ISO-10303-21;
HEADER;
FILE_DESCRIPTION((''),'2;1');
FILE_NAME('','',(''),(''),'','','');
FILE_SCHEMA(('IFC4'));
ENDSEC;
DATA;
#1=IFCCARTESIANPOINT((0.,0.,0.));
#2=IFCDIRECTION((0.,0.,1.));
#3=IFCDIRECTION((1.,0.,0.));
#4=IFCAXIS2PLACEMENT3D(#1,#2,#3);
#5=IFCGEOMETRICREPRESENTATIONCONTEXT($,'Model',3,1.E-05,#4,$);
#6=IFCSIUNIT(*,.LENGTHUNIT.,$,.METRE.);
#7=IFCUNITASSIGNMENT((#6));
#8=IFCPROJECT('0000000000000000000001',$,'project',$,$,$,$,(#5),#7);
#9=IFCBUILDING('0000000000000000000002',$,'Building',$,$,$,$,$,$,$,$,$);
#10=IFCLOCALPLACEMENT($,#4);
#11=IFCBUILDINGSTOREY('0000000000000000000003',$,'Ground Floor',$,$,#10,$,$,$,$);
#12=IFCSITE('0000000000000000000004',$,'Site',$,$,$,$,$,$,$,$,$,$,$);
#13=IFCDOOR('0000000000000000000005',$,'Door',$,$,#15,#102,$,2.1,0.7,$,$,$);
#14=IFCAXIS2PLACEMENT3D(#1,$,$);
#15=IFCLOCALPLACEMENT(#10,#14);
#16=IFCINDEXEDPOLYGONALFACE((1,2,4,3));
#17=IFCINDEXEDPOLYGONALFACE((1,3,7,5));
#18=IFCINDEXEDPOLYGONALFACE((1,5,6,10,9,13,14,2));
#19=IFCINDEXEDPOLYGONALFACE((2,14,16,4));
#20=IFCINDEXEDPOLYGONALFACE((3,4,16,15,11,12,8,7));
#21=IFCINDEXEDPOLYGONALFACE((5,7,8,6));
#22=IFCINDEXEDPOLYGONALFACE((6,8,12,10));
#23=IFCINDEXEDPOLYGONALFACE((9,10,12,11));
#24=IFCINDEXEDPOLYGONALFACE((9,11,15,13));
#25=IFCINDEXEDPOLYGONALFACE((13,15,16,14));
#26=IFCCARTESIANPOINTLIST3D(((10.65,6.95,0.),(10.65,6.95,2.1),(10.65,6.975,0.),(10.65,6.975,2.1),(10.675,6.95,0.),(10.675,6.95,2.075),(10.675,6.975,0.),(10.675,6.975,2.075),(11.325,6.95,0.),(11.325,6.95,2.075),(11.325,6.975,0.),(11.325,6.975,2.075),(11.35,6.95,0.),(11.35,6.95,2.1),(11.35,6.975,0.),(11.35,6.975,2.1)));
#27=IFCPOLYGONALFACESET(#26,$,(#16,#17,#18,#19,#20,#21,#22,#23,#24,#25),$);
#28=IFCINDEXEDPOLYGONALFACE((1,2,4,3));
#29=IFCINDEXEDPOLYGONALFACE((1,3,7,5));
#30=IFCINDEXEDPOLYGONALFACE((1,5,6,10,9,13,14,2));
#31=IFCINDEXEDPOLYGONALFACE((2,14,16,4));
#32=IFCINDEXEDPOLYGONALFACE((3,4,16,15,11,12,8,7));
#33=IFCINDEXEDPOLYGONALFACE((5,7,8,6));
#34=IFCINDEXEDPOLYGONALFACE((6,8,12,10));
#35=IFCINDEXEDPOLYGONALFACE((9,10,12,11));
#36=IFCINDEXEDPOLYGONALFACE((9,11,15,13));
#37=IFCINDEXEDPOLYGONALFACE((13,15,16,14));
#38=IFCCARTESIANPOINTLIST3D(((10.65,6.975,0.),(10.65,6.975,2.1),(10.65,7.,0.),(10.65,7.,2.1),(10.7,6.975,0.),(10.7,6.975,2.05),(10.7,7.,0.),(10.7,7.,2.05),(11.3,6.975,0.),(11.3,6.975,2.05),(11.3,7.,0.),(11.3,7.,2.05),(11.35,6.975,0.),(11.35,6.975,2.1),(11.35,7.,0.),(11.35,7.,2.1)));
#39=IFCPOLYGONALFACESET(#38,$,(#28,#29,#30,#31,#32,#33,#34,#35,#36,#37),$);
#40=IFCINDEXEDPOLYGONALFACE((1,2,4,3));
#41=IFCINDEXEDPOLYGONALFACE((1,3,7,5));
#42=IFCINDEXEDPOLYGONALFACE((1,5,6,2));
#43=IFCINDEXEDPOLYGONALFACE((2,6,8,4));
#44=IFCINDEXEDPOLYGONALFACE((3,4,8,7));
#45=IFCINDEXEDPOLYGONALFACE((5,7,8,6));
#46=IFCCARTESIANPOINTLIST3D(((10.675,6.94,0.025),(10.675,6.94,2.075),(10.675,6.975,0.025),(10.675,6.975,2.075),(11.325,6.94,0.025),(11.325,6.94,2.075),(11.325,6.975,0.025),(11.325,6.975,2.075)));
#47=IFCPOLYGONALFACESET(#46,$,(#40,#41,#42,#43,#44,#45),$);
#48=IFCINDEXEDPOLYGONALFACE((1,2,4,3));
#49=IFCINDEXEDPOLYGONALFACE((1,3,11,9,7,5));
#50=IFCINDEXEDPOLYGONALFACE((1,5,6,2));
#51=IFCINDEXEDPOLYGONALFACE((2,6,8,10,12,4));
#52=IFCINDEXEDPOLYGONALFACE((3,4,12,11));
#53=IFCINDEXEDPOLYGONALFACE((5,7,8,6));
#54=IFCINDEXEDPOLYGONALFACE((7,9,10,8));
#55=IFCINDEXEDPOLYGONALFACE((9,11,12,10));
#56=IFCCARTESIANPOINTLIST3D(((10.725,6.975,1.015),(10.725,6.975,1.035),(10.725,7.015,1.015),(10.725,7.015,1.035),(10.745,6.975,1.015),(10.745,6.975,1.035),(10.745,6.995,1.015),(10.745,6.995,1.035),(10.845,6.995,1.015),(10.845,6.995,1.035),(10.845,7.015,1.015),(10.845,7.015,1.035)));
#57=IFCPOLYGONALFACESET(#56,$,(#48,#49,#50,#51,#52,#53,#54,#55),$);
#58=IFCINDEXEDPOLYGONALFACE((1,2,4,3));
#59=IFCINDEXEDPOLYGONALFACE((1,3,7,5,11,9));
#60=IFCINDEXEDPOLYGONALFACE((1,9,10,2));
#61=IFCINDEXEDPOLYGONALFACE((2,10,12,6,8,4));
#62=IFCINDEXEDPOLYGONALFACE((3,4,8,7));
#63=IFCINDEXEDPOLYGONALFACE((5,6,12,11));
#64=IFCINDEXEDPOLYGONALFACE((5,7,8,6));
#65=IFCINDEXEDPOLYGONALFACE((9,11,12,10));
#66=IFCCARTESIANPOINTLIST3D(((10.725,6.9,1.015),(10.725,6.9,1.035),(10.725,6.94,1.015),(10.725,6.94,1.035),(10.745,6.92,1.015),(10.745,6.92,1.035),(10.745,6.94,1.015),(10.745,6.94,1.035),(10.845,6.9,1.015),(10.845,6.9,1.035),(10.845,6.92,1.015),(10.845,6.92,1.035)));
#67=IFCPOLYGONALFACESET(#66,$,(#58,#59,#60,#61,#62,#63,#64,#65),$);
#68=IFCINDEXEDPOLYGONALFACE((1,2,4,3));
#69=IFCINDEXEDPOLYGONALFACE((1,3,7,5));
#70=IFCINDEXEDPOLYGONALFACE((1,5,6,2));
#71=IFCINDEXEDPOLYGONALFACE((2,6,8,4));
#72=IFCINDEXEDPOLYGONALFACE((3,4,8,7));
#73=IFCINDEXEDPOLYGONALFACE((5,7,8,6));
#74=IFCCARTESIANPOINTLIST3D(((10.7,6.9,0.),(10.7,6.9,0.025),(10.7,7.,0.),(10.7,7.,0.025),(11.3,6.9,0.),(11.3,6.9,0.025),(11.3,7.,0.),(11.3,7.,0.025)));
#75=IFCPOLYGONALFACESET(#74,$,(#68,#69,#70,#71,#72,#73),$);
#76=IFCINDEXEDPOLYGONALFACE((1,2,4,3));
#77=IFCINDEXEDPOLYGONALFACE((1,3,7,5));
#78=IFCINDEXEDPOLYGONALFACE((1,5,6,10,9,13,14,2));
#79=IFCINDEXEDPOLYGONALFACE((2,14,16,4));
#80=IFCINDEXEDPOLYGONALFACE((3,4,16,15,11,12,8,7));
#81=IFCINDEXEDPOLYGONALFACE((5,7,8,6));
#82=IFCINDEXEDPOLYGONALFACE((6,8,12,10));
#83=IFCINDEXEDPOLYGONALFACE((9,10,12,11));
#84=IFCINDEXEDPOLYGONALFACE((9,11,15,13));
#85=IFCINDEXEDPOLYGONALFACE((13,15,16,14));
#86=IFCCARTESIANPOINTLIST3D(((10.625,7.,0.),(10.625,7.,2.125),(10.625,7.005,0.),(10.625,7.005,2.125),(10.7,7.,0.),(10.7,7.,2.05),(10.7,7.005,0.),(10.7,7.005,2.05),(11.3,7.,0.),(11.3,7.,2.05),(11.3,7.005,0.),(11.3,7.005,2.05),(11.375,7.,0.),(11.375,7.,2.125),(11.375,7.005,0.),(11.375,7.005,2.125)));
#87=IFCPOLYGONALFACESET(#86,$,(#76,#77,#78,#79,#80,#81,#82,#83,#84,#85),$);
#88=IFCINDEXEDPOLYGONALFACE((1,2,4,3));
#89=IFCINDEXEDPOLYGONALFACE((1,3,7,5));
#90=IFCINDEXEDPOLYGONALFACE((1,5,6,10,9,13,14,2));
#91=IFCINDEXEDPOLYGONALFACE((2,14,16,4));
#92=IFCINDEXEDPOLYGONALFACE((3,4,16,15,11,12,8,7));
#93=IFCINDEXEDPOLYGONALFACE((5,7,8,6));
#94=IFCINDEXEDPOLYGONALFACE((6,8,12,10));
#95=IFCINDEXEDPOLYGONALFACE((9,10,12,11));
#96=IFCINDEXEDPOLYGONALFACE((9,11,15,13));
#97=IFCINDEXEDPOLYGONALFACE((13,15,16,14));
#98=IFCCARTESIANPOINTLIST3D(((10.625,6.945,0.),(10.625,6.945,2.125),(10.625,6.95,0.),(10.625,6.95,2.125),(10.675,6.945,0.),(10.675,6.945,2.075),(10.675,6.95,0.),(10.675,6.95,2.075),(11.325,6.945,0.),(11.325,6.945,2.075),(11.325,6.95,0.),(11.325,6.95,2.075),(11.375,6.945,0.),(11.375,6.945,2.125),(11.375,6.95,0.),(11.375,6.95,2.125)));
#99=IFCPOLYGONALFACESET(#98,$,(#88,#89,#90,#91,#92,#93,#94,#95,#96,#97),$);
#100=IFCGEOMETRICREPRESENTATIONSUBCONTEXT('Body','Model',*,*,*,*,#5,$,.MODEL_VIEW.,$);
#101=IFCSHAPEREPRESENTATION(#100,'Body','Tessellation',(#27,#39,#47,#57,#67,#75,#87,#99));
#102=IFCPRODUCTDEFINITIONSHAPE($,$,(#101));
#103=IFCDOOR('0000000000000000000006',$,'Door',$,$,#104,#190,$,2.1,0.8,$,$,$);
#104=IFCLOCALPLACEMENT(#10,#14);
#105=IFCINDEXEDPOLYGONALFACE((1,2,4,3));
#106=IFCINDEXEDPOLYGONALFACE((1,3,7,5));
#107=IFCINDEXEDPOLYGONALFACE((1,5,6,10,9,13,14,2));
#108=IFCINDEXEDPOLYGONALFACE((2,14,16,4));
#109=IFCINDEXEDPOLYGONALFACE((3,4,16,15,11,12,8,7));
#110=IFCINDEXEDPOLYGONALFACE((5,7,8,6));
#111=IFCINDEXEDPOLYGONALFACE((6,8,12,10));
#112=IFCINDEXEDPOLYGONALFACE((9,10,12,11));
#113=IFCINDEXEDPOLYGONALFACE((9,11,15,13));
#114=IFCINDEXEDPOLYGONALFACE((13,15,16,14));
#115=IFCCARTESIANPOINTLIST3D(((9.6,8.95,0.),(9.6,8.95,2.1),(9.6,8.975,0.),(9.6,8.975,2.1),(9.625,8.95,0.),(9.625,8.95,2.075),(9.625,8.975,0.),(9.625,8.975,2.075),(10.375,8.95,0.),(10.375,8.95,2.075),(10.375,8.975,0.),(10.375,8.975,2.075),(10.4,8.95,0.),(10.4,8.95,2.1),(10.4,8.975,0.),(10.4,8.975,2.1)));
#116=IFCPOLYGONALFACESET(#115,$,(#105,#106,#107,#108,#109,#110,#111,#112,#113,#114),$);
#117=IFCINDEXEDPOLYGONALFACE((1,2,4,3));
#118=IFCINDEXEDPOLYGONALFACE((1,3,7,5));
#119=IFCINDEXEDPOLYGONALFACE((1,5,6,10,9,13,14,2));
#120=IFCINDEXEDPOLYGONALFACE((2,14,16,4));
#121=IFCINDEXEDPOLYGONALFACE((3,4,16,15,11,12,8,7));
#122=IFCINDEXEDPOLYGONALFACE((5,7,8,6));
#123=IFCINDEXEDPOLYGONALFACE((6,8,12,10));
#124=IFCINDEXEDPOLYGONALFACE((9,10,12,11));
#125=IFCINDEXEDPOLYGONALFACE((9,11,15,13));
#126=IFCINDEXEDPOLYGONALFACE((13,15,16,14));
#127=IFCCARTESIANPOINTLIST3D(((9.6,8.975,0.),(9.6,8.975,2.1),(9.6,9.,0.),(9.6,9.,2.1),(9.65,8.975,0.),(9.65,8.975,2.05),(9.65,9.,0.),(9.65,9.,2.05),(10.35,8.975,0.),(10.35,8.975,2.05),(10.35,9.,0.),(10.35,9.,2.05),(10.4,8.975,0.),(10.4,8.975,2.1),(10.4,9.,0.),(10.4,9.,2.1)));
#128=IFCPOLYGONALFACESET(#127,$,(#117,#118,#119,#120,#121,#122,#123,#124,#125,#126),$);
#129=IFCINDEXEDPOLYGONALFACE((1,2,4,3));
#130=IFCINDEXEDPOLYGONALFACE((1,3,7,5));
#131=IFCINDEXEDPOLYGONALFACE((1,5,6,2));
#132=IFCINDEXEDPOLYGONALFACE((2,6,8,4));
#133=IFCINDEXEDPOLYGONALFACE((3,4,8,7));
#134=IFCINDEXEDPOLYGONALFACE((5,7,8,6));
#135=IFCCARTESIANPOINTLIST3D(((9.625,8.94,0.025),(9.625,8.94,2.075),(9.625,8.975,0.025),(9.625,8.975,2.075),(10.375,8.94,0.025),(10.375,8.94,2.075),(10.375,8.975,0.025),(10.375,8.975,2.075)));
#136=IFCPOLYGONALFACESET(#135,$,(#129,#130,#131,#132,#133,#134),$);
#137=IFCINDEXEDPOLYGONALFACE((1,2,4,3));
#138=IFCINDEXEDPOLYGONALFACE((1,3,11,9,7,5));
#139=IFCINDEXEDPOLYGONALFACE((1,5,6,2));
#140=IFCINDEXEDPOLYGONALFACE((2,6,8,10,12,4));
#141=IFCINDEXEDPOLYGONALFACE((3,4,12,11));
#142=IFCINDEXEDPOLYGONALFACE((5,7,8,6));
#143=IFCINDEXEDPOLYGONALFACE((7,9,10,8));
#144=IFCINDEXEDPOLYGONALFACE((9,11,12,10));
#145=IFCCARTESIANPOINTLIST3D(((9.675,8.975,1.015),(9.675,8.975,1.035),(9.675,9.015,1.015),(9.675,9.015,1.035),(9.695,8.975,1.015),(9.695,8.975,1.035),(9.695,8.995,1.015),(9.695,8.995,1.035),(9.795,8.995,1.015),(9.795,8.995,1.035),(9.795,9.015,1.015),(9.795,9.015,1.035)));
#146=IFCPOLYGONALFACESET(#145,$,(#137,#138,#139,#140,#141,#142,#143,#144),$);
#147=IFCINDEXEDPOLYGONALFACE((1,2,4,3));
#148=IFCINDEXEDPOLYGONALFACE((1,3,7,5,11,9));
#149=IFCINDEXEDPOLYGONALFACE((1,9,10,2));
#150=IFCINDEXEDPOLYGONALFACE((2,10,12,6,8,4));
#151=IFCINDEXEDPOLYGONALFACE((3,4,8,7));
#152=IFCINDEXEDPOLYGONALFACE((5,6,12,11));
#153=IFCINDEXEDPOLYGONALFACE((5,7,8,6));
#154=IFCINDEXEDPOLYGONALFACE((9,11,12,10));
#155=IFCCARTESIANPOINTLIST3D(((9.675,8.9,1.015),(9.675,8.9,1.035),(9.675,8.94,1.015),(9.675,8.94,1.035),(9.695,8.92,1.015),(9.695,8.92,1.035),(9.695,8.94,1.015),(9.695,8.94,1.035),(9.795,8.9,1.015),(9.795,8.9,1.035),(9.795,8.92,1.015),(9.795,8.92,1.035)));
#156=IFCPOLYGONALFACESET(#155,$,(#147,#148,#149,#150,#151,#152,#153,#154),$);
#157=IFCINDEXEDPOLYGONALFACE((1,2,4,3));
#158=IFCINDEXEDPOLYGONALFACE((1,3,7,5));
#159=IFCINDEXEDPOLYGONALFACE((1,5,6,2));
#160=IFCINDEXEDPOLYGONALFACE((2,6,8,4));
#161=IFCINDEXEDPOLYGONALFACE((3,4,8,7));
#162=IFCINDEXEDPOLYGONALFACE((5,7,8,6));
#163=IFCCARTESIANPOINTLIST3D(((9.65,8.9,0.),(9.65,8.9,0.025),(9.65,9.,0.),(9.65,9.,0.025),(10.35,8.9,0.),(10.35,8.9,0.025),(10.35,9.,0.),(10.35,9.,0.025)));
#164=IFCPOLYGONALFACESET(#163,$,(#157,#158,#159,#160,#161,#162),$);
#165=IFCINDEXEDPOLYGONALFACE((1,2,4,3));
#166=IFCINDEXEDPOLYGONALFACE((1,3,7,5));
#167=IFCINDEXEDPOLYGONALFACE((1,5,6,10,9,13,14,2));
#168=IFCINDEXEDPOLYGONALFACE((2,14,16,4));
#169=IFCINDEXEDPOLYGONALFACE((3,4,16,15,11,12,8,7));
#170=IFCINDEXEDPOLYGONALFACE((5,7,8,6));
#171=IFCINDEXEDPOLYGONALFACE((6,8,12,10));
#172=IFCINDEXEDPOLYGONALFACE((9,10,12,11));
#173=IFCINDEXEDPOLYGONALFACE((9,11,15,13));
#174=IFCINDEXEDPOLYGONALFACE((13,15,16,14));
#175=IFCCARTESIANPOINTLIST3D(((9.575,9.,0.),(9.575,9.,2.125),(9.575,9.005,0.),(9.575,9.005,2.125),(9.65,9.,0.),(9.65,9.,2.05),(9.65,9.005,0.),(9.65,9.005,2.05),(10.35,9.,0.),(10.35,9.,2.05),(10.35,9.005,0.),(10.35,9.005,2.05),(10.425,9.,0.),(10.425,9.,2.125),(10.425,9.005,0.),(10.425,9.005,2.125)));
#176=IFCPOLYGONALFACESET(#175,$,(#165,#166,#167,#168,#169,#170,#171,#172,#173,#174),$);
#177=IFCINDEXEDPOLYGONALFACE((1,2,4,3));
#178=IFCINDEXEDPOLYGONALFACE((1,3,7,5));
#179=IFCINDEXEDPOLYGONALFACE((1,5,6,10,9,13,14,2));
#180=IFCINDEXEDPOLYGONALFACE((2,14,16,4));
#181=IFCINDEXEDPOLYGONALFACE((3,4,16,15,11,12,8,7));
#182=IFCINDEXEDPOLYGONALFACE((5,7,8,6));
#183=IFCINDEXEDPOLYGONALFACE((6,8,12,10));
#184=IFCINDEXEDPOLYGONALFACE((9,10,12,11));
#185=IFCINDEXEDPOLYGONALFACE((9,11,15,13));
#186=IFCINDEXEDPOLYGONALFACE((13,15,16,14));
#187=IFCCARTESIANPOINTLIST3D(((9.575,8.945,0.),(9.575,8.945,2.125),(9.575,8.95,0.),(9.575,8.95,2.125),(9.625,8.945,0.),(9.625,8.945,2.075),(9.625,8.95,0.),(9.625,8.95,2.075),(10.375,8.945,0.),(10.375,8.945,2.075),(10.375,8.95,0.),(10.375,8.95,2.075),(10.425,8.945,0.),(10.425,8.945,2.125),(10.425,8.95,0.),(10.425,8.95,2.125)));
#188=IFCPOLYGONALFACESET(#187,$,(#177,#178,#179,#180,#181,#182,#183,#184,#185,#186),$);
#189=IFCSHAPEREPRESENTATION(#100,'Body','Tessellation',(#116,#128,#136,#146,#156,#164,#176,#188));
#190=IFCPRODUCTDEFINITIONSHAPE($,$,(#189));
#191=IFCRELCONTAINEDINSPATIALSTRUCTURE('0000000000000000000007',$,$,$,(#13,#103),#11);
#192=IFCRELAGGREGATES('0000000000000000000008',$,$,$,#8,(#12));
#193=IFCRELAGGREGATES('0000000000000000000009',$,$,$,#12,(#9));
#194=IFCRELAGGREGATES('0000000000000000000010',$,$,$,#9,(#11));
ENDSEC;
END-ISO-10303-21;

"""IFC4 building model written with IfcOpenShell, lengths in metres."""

from ifc_helpers import new_model, si_unit, frame, origin_with_axes, place, context, subcontext, project, spatial, line, indexed_curve, outline, extrude, element, save


model = new_model("IFC4")

# Units and contexts
model_context = context("Model", 3, precision=1e-05, world=origin_with_axes())
body_context = subcontext(model_context, "Body", "Model", "MODEL_VIEW")
ifc_project = project(units=[si_unit("LENGTHUNIT", "METRE")], contexts=[model_context])

# Site, building, storey
site = spatial("IfcSite", under=ifc_project, Name="Site")
building = spatial("IfcBuilding", under=site, Name="Building")
storey_placement = place(None, origin_with_axes())
storey = spatial("IfcBuildingStorey", under=building, at=storey_placement, Name="Ground Floor")

# Doors
door_1_placement = place(storey_placement, frame((11.35, 7.0, 0.0), z_axis=(0.0, 0.0, 1.0), x_axis=(-1.0, 0.0, 0.0)))
element("IfcDoor", 1, at=door_1_placement, inside=storey, Name="Door", OverallHeight=2.1, OverallWidth=0.7, context=body_context, shape_type="SweptSolid", body=[
    extrude(outline(indexed_curve([(0.0, 0.0), (0.0, 2.1), (0.7, 2.1), (0.7, 0.0), (0.675, 0.0), (0.675, 2.075), (0.025, 2.075), (0.025, 0.0)], segments=[line(1, 2, 3, 4, 5, 6, 7, 8, 1)])), frame((0.0, 0.025, 0.0), z_axis=(0.0, -1.0, 0.0), x_axis=(1.0, 0.0, 0.0)), (0.0, 0.0, -1.0), 0.025),
    extrude(outline(indexed_curve([(0.0, 0.0), (0.0, 2.1), (0.7, 2.1), (0.7, 0.0), (0.65, 0.0), (0.65, 2.05), (0.05, 2.05), (0.05, 0.0)], segments=[line(1, 2, 3, 4, 5, 6, 7, 8, 1)])), frame((0.0, 0.0, 0.0), z_axis=(0.0, -1.0, 0.0), x_axis=(1.0, 0.0, 0.0)), (0.0, 0.0, -1.0), 0.025),
    extrude(outline(indexed_curve([(0.0, 0.0), (0.65, 0.0), (0.65, 0.035), (0.0, 0.035)], segments=[line(1, 2, 3, 4, 1)])), frame((0.025, 0.025, 0.025), z_axis=(0.0, 0.0, 1.0), x_axis=(1.0, 0.0, 0.0)), (0.0, 0.0, 1.0), 2.05),
    extrude(outline(indexed_curve([(0.0, 0.0), (0.0, -0.04), (-0.12, -0.04), (-0.12, -0.02), (-0.02, -0.02), (-0.02, 0.0)], segments=[line(1, 2, 3, 4, 5, 6, 1)])), frame((0.625, 0.025, 1.015), z_axis=(0.0, 0.0, 1.0), x_axis=(1.0, 0.0, 0.0)), (0.0, 0.0, 1.0), 0.02),
    extrude(outline(indexed_curve([(0.0, 0.0), (0.0, 0.04), (-0.12, 0.04), (-0.12, 0.02), (-0.02, 0.02), (-0.02, 0.0)], segments=[line(1, 2, 3, 4, 5, 6, 1)])), frame((0.625, 0.06, 1.015), z_axis=(0.0, 0.0, 1.0), x_axis=(1.0, 0.0, 0.0)), (0.0, 0.0, 1.0), 0.02),
    extrude(outline(indexed_curve([(0.0, 0.0), (0.6, 0.0), (0.6, 0.1), (0.0, 0.1)], segments=[line(1, 2, 3, 4, 1)])), frame((0.05, 0.0, 0.0), z_axis=(0.0, 0.0, 1.0), x_axis=(1.0, 0.0, 0.0)), (0.0, 0.0, 1.0), 0.025),
    extrude(outline(indexed_curve([(0.0, 0.0), (0.0, 2.125), (0.75, 2.125), (0.75, 0.0), (0.675, 0.0), (0.675, 2.05), (0.075, 2.05), (0.075, 0.0)], segments=[line(1, 2, 3, 4, 5, 6, 7, 8, 1)])), frame((-0.025, -0.005, 0.0), z_axis=(0.0, -1.0, 0.0), x_axis=(1.0, 0.0, 0.0)), (0.0, 0.0, -1.0), 0.005),
    extrude(outline(indexed_curve([(0.0, 0.0), (0.0, 2.125), (0.75, 2.125), (0.75, 0.0), (0.7, 0.0), (0.7, 2.075), (0.05, 2.075), (0.05, 0.0)], segments=[line(1, 2, 3, 4, 5, 6, 7, 8, 1)])), frame((-0.025, 0.05, 0.0), z_axis=(0.0, -1.0, 0.0), x_axis=(1.0, 0.0, 0.0)), (0.0, 0.0, -1.0), 0.005),
])
door_2_placement = place(storey_placement, frame((10.4, 9.0, 0.0), z_axis=(0.0, 0.0, 1.0), x_axis=(-1.0, 0.0, 0.0)))
element("IfcDoor", 2, at=door_2_placement, inside=storey, Name="Door", OverallHeight=2.1, OverallWidth=0.8, context=body_context, shape_type="SweptSolid", body=[
    extrude(outline(indexed_curve([(0.0, 0.0), (0.0, 2.1), (0.8, 2.1), (0.8, 0.0), (0.775, 0.0), (0.775, 2.075), (0.025, 2.075), (0.025, 0.0)], segments=[line(1, 2, 3, 4, 5, 6, 7, 8, 1)])), frame((0.0, 0.025, 0.0), z_axis=(0.0, -1.0, 0.0), x_axis=(1.0, 0.0, 0.0)), (0.0, 0.0, -1.0), 0.025),
    extrude(outline(indexed_curve([(0.0, 0.0), (0.0, 2.1), (0.8, 2.1), (0.8, 0.0), (0.75, 0.0), (0.75, 2.05), (0.05, 2.05), (0.05, 0.0)], segments=[line(1, 2, 3, 4, 5, 6, 7, 8, 1)])), frame((0.0, 0.0, 0.0), z_axis=(0.0, -1.0, 0.0), x_axis=(1.0, 0.0, 0.0)), (0.0, 0.0, -1.0), 0.025),
    extrude(outline(indexed_curve([(0.0, 0.0), (0.75, 0.0), (0.75, 0.035), (0.0, 0.035)], segments=[line(1, 2, 3, 4, 1)])), frame((0.025, 0.025, 0.025), z_axis=(0.0, 0.0, 1.0), x_axis=(1.0, 0.0, 0.0)), (0.0, 0.0, 1.0), 2.05),
    extrude(outline(indexed_curve([(0.0, 0.0), (0.0, -0.04), (-0.12, -0.04), (-0.12, -0.02), (-0.02, -0.02), (-0.02, 0.0)], segments=[line(1, 2, 3, 4, 5, 6, 1)])), frame((0.725, 0.025, 1.015), z_axis=(0.0, 0.0, 1.0), x_axis=(1.0, 0.0, 0.0)), (0.0, 0.0, 1.0), 0.02),
    extrude(outline(indexed_curve([(0.0, 0.0), (0.0, 0.04), (-0.12, 0.04), (-0.12, 0.02), (-0.02, 0.02), (-0.02, 0.0)], segments=[line(1, 2, 3, 4, 5, 6, 1)])), frame((0.725, 0.06, 1.015), z_axis=(0.0, 0.0, 1.0), x_axis=(1.0, 0.0, 0.0)), (0.0, 0.0, 1.0), 0.02),
    extrude(outline(indexed_curve([(0.0, 0.0), (0.7, 0.0), (0.7, 0.1), (0.0, 0.1)], segments=[line(1, 2, 3, 4, 1)])), frame((0.05, 0.0, 0.0), z_axis=(0.0, 0.0, 1.0), x_axis=(1.0, 0.0, 0.0)), (0.0, 0.0, 1.0), 0.025),
    extrude(outline(indexed_curve([(0.0, 0.0), (0.0, 2.125), (0.85, 2.125), (0.85, 0.0), (0.775, 0.0), (0.775, 2.05), (0.075, 2.05), (0.075, 0.0)], segments=[line(1, 2, 3, 4, 5, 6, 7, 8, 1)])), frame((-0.025, -0.005, 0.0), z_axis=(0.0, -1.0, 0.0), x_axis=(1.0, 0.0, 0.0)), (0.0, 0.0, -1.0), 0.005),
    extrude(outline(indexed_curve([(0.0, 0.0), (0.0, 2.125), (0.85, 2.125), (0.85, 0.0), (0.8, 0.0), (0.8, 2.075), (0.05, 2.075), (0.05, 0.0)], segments=[line(1, 2, 3, 4, 5, 6, 7, 8, 1)])), frame((-0.025, 0.05, 0.0), z_axis=(0.0, -1.0, 0.0), x_axis=(1.0, 0.0, 0.0)), (0.0, 0.0, -1.0), 0.005),
])

save(model, "model.ifc")
